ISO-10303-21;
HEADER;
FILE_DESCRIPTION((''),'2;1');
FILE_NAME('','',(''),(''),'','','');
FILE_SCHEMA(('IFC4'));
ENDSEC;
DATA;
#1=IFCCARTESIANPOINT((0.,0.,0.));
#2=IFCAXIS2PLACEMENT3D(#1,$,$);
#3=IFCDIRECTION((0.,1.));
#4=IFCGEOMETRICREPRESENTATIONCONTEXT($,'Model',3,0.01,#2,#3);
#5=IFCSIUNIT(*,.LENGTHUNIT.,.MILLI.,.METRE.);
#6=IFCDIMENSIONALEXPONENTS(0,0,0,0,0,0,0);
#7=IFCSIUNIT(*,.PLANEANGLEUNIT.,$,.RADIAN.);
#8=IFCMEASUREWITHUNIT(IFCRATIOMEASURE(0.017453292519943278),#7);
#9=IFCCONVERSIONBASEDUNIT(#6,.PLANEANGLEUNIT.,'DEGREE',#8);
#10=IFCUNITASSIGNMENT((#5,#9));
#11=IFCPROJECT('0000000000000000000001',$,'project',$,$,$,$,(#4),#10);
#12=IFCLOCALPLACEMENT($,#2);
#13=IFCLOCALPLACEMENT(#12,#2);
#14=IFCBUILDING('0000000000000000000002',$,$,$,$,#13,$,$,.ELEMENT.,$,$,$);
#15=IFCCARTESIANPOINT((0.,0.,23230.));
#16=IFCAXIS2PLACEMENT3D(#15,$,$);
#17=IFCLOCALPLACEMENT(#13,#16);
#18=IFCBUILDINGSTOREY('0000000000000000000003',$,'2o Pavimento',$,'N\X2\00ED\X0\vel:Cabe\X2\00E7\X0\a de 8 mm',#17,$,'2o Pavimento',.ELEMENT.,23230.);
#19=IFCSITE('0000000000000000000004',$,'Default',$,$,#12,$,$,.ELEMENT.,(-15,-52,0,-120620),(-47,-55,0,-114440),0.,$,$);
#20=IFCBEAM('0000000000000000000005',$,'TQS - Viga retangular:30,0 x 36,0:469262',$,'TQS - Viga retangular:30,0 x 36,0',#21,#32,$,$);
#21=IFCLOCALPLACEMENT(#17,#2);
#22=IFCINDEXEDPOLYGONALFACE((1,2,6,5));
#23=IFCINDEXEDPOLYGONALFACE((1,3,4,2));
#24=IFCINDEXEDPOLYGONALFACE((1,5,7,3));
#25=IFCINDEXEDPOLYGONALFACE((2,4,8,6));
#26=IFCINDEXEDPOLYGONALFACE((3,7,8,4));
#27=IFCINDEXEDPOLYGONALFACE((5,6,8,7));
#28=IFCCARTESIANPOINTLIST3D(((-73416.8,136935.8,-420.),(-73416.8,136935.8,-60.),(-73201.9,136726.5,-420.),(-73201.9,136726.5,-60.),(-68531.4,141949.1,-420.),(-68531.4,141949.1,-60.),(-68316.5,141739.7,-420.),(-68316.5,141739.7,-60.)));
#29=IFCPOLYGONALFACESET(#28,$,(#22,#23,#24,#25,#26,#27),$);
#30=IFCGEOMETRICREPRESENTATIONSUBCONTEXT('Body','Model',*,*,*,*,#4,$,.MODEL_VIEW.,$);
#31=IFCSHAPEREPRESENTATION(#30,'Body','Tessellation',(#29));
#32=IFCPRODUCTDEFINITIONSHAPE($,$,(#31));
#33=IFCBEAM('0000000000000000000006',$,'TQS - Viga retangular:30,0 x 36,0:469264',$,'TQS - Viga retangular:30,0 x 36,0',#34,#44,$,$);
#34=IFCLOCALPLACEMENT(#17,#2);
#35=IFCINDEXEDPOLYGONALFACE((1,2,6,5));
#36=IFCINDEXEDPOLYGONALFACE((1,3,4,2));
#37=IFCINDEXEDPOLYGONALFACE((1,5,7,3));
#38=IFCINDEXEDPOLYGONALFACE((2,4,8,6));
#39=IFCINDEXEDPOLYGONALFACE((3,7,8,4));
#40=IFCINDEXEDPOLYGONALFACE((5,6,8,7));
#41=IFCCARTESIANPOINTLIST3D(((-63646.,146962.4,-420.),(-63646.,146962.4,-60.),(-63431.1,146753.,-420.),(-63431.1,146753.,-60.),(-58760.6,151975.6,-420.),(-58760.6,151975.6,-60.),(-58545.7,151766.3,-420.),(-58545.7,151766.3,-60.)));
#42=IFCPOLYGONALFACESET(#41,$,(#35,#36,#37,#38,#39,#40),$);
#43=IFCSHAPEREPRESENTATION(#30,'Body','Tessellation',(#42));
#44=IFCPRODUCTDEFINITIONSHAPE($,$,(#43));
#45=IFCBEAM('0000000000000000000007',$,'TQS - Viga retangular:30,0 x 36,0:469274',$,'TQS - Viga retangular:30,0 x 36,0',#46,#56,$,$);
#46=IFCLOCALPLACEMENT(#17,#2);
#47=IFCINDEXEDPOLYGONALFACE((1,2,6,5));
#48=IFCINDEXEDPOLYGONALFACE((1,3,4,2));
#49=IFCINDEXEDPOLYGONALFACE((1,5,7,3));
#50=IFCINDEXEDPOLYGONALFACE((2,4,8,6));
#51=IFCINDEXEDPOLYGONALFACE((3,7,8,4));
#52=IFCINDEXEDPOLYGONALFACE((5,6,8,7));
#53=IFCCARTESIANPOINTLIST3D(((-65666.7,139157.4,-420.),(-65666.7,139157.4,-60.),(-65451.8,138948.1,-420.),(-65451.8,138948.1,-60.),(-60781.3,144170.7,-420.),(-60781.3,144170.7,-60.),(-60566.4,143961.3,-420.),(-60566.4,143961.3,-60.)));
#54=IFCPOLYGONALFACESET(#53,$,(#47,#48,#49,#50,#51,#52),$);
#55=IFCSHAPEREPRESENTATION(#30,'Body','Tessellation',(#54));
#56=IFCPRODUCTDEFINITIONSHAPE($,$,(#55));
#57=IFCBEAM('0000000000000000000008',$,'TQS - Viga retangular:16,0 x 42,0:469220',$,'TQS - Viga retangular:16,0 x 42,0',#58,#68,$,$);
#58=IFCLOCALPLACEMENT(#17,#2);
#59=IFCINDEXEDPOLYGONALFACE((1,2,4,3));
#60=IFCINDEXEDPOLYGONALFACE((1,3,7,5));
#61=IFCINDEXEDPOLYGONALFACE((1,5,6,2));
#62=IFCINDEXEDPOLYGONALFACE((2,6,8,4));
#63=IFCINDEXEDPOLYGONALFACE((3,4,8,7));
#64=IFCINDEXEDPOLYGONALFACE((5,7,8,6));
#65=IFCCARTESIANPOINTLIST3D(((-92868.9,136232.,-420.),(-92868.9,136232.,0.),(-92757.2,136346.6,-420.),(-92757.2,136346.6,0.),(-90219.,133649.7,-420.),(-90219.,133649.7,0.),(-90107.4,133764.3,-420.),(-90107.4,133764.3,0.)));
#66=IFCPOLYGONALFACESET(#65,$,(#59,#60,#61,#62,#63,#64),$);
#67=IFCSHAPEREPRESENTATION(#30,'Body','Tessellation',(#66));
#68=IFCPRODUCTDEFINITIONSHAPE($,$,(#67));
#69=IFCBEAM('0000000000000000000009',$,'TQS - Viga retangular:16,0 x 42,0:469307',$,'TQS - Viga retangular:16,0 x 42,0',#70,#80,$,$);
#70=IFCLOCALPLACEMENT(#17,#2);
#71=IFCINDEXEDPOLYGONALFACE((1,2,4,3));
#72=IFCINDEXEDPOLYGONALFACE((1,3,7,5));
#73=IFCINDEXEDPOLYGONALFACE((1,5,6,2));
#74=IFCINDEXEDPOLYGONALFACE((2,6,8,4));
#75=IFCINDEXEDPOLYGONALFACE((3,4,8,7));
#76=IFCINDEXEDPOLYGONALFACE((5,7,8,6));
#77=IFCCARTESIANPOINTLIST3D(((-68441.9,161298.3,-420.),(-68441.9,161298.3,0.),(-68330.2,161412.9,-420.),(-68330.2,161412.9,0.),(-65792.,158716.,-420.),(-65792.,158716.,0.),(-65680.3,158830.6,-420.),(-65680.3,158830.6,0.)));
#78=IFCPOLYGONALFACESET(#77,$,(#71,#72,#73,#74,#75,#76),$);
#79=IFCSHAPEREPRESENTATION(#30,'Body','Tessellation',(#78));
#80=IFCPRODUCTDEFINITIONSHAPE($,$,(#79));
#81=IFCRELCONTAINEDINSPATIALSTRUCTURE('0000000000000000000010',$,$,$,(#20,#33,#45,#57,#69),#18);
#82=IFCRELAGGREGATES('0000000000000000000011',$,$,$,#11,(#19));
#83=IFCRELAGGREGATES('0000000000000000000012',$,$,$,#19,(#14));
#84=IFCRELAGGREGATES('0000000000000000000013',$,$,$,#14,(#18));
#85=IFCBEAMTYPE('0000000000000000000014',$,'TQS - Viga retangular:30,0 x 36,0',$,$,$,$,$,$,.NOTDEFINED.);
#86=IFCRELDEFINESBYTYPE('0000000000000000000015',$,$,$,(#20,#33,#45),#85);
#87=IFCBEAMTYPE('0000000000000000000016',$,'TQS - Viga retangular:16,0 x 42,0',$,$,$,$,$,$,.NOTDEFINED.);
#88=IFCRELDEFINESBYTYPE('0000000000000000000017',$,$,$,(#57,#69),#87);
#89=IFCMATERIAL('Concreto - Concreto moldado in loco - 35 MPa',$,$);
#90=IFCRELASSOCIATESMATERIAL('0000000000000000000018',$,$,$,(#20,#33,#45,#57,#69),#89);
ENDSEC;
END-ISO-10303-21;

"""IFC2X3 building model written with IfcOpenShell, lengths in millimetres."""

from ifc_helpers import new_model, entity, si_unit, converted_unit, direction, frame, frame_2d, origin, place, context, subcontext, project, spatial, rectangle, extrude, material, type_object, element, save


model = new_model("IFC2X3")

# Units and contexts
model_context = context("Model", 3, precision=0.01, world=origin(), true_north=direction((0.0, 1.0)))
body_context = subcontext(model_context, "Body", "Model", "MODEL_VIEW")
ifc_project = project(units=[si_unit("LENGTHUNIT", "METRE", prefix="MILLI"), converted_unit("PLANEANGLEUNIT", "DEGREE", entity("IfcRatioMeasure", 0.017453292519943278), si_unit("PLANEANGLEUNIT", "RADIAN"), dimensions=[0, 0, 0, 0, 0, 0, 0])], contexts=[model_context])

# Site, building, storey
site_placement = place(None, origin())
site = spatial("IfcSite", under=ifc_project, at=site_placement, Name="Default", CompositionType="ELEMENT", RefLatitude=(-15, -52, 0, -120620), RefLongitude=(-47, -55, 0, -114440), RefElevation=0.0)
building_placement = place(site_placement, origin())
building = spatial("IfcBuilding", under=site, at=building_placement, CompositionType="ELEMENT")
storey_placement = place(building_placement, frame((0.0, 0.0, 23230.0)))
storey = spatial("IfcBuildingStorey", under=building, at=storey_placement, Name="2o Pavimento", ObjectType="Nível:Cabeça de 8 mm", LongName="2o Pavimento", CompositionType="ELEMENT", Elevation=23230.0)

# Beams
ifc_material = material(Name="Concreto - Concreto moldado in loco - 35 MPa")
beam_type_1 = type_object("IfcBeamType", Name="TQS - Viga retangular:30,0 x 36,0", PredefinedType="NOTDEFINED")
beam_1_placement = place(storey_placement, frame((-73309.4, 136831.2, -60.0), z_axis=(0.0, 0.0, 1.0), x_axis=(0.697915, 0.71618, 0.0)))
element("IfcBeam", 1, at=beam_1_placement, inside=storey, type_object=beam_type_1, material=ifc_material, Name="TQS - Viga retangular:30,0 x 36,0:469262", ObjectType="TQS - Viga retangular:30,0 x 36,0", context=body_context, shape_type="SweptSolid", body=[
    extrude(rectangle(XDim=360.0, YDim=300.0, at=frame_2d((0.0, 0.0), x_axis=(1.0, 0.0))), frame((0.0, 0.0, -180.0), z_axis=(1.0, 0.0, 0.0), x_axis=(0.0, 0.0, -1.0)), (0.0, 0.0, 1.0), 7000.0),
])
beam_2_placement = place(storey_placement, frame((-63538.6, 146857.7, -60.0), z_axis=(0.0, 0.0, 1.0), x_axis=(0.697915, 0.71618, 0.0)))
element("IfcBeam", 2, at=beam_2_placement, inside=storey, type_object=beam_type_1, material=ifc_material, Name="TQS - Viga retangular:30,0 x 36,0:469264", ObjectType="TQS - Viga retangular:30,0 x 36,0", context=body_context, shape_type="SweptSolid", body=[
    extrude(rectangle(XDim=360.0, YDim=300.0, at=frame_2d((0.0, 0.0), x_axis=(1.0, 0.0))), frame((0.0, 0.0, -180.0), z_axis=(1.0, 0.0, 0.0), x_axis=(0.0, 0.0, -1.0)), (0.0, 0.0, 1.0), 7000.0),
])
beam_3_placement = place(storey_placement, frame((-65559.2, 139052.8, -60.0), z_axis=(0.0, 0.0, 1.0), x_axis=(0.697915, 0.71618, 0.0)))
element("IfcBeam", 3, at=beam_3_placement, inside=storey, type_object=beam_type_1, material=ifc_material, Name="TQS - Viga retangular:30,0 x 36,0:469274", ObjectType="TQS - Viga retangular:30,0 x 36,0", context=body_context, shape_type="SweptSolid", body=[
    extrude(rectangle(XDim=360.0, YDim=300.0, at=frame_2d((0.0, 0.0), x_axis=(1.0, 0.0))), frame((0.0, 0.0, -180.0), z_axis=(1.0, 0.0, 0.0), x_axis=(0.0, 0.0, -1.0)), (0.0, 0.0, 1.0), 7000.0),
])
beam_type_2 = type_object("IfcBeamType", Name="TQS - Viga retangular:16,0 x 42,0", PredefinedType="NOTDEFINED")
beam_4_placement = place(storey_placement, frame((-90105.9, 133651.2, 0.0), z_axis=(0.0, 0.0, 1.0), x_axis=(-0.71618, 0.697915, 0.0)))
element("IfcBeam", 4, at=beam_4_placement, inside=storey, type_object=beam_type_2, material=ifc_material, Name="TQS - Viga retangular:16,0 x 42,0:469220", ObjectType="TQS - Viga retangular:16,0 x 42,0", context=body_context, shape_type="SweptSolid", body=[
    extrude(rectangle(XDim=420.0, YDim=160.0, at=frame_2d((0.0, 0.0), x_axis=(1.0, 0.0))), frame((80.0, 0.0, -210.0), z_axis=(1.0, 0.0, 0.0), x_axis=(0.0, 0.0, -1.0)), (0.0, 0.0, 1.0), 3700.0),
])
beam_5_placement = place(storey_placement, frame((-65678.9, 158717.5, 0.0), z_axis=(0.0, 0.0, 1.0), x_axis=(-0.71618, 0.697915, 0.0)))
element("IfcBeam", 5, at=beam_5_placement, inside=storey, type_object=beam_type_2, material=ifc_material, Name="TQS - Viga retangular:16,0 x 42,0:469307", ObjectType="TQS - Viga retangular:16,0 x 42,0", context=body_context, shape_type="SweptSolid", body=[
    extrude(rectangle(XDim=420.0, YDim=160.0, at=frame_2d((0.0, 0.0), x_axis=(1.0, 0.0))), frame((80.0, 0.0, -210.0), z_axis=(1.0, 0.0, 0.0), x_axis=(0.0, 0.0, -1.0)), (0.0, 0.0, 1.0), 3700.0),
])

save(model, "model.ifc")
